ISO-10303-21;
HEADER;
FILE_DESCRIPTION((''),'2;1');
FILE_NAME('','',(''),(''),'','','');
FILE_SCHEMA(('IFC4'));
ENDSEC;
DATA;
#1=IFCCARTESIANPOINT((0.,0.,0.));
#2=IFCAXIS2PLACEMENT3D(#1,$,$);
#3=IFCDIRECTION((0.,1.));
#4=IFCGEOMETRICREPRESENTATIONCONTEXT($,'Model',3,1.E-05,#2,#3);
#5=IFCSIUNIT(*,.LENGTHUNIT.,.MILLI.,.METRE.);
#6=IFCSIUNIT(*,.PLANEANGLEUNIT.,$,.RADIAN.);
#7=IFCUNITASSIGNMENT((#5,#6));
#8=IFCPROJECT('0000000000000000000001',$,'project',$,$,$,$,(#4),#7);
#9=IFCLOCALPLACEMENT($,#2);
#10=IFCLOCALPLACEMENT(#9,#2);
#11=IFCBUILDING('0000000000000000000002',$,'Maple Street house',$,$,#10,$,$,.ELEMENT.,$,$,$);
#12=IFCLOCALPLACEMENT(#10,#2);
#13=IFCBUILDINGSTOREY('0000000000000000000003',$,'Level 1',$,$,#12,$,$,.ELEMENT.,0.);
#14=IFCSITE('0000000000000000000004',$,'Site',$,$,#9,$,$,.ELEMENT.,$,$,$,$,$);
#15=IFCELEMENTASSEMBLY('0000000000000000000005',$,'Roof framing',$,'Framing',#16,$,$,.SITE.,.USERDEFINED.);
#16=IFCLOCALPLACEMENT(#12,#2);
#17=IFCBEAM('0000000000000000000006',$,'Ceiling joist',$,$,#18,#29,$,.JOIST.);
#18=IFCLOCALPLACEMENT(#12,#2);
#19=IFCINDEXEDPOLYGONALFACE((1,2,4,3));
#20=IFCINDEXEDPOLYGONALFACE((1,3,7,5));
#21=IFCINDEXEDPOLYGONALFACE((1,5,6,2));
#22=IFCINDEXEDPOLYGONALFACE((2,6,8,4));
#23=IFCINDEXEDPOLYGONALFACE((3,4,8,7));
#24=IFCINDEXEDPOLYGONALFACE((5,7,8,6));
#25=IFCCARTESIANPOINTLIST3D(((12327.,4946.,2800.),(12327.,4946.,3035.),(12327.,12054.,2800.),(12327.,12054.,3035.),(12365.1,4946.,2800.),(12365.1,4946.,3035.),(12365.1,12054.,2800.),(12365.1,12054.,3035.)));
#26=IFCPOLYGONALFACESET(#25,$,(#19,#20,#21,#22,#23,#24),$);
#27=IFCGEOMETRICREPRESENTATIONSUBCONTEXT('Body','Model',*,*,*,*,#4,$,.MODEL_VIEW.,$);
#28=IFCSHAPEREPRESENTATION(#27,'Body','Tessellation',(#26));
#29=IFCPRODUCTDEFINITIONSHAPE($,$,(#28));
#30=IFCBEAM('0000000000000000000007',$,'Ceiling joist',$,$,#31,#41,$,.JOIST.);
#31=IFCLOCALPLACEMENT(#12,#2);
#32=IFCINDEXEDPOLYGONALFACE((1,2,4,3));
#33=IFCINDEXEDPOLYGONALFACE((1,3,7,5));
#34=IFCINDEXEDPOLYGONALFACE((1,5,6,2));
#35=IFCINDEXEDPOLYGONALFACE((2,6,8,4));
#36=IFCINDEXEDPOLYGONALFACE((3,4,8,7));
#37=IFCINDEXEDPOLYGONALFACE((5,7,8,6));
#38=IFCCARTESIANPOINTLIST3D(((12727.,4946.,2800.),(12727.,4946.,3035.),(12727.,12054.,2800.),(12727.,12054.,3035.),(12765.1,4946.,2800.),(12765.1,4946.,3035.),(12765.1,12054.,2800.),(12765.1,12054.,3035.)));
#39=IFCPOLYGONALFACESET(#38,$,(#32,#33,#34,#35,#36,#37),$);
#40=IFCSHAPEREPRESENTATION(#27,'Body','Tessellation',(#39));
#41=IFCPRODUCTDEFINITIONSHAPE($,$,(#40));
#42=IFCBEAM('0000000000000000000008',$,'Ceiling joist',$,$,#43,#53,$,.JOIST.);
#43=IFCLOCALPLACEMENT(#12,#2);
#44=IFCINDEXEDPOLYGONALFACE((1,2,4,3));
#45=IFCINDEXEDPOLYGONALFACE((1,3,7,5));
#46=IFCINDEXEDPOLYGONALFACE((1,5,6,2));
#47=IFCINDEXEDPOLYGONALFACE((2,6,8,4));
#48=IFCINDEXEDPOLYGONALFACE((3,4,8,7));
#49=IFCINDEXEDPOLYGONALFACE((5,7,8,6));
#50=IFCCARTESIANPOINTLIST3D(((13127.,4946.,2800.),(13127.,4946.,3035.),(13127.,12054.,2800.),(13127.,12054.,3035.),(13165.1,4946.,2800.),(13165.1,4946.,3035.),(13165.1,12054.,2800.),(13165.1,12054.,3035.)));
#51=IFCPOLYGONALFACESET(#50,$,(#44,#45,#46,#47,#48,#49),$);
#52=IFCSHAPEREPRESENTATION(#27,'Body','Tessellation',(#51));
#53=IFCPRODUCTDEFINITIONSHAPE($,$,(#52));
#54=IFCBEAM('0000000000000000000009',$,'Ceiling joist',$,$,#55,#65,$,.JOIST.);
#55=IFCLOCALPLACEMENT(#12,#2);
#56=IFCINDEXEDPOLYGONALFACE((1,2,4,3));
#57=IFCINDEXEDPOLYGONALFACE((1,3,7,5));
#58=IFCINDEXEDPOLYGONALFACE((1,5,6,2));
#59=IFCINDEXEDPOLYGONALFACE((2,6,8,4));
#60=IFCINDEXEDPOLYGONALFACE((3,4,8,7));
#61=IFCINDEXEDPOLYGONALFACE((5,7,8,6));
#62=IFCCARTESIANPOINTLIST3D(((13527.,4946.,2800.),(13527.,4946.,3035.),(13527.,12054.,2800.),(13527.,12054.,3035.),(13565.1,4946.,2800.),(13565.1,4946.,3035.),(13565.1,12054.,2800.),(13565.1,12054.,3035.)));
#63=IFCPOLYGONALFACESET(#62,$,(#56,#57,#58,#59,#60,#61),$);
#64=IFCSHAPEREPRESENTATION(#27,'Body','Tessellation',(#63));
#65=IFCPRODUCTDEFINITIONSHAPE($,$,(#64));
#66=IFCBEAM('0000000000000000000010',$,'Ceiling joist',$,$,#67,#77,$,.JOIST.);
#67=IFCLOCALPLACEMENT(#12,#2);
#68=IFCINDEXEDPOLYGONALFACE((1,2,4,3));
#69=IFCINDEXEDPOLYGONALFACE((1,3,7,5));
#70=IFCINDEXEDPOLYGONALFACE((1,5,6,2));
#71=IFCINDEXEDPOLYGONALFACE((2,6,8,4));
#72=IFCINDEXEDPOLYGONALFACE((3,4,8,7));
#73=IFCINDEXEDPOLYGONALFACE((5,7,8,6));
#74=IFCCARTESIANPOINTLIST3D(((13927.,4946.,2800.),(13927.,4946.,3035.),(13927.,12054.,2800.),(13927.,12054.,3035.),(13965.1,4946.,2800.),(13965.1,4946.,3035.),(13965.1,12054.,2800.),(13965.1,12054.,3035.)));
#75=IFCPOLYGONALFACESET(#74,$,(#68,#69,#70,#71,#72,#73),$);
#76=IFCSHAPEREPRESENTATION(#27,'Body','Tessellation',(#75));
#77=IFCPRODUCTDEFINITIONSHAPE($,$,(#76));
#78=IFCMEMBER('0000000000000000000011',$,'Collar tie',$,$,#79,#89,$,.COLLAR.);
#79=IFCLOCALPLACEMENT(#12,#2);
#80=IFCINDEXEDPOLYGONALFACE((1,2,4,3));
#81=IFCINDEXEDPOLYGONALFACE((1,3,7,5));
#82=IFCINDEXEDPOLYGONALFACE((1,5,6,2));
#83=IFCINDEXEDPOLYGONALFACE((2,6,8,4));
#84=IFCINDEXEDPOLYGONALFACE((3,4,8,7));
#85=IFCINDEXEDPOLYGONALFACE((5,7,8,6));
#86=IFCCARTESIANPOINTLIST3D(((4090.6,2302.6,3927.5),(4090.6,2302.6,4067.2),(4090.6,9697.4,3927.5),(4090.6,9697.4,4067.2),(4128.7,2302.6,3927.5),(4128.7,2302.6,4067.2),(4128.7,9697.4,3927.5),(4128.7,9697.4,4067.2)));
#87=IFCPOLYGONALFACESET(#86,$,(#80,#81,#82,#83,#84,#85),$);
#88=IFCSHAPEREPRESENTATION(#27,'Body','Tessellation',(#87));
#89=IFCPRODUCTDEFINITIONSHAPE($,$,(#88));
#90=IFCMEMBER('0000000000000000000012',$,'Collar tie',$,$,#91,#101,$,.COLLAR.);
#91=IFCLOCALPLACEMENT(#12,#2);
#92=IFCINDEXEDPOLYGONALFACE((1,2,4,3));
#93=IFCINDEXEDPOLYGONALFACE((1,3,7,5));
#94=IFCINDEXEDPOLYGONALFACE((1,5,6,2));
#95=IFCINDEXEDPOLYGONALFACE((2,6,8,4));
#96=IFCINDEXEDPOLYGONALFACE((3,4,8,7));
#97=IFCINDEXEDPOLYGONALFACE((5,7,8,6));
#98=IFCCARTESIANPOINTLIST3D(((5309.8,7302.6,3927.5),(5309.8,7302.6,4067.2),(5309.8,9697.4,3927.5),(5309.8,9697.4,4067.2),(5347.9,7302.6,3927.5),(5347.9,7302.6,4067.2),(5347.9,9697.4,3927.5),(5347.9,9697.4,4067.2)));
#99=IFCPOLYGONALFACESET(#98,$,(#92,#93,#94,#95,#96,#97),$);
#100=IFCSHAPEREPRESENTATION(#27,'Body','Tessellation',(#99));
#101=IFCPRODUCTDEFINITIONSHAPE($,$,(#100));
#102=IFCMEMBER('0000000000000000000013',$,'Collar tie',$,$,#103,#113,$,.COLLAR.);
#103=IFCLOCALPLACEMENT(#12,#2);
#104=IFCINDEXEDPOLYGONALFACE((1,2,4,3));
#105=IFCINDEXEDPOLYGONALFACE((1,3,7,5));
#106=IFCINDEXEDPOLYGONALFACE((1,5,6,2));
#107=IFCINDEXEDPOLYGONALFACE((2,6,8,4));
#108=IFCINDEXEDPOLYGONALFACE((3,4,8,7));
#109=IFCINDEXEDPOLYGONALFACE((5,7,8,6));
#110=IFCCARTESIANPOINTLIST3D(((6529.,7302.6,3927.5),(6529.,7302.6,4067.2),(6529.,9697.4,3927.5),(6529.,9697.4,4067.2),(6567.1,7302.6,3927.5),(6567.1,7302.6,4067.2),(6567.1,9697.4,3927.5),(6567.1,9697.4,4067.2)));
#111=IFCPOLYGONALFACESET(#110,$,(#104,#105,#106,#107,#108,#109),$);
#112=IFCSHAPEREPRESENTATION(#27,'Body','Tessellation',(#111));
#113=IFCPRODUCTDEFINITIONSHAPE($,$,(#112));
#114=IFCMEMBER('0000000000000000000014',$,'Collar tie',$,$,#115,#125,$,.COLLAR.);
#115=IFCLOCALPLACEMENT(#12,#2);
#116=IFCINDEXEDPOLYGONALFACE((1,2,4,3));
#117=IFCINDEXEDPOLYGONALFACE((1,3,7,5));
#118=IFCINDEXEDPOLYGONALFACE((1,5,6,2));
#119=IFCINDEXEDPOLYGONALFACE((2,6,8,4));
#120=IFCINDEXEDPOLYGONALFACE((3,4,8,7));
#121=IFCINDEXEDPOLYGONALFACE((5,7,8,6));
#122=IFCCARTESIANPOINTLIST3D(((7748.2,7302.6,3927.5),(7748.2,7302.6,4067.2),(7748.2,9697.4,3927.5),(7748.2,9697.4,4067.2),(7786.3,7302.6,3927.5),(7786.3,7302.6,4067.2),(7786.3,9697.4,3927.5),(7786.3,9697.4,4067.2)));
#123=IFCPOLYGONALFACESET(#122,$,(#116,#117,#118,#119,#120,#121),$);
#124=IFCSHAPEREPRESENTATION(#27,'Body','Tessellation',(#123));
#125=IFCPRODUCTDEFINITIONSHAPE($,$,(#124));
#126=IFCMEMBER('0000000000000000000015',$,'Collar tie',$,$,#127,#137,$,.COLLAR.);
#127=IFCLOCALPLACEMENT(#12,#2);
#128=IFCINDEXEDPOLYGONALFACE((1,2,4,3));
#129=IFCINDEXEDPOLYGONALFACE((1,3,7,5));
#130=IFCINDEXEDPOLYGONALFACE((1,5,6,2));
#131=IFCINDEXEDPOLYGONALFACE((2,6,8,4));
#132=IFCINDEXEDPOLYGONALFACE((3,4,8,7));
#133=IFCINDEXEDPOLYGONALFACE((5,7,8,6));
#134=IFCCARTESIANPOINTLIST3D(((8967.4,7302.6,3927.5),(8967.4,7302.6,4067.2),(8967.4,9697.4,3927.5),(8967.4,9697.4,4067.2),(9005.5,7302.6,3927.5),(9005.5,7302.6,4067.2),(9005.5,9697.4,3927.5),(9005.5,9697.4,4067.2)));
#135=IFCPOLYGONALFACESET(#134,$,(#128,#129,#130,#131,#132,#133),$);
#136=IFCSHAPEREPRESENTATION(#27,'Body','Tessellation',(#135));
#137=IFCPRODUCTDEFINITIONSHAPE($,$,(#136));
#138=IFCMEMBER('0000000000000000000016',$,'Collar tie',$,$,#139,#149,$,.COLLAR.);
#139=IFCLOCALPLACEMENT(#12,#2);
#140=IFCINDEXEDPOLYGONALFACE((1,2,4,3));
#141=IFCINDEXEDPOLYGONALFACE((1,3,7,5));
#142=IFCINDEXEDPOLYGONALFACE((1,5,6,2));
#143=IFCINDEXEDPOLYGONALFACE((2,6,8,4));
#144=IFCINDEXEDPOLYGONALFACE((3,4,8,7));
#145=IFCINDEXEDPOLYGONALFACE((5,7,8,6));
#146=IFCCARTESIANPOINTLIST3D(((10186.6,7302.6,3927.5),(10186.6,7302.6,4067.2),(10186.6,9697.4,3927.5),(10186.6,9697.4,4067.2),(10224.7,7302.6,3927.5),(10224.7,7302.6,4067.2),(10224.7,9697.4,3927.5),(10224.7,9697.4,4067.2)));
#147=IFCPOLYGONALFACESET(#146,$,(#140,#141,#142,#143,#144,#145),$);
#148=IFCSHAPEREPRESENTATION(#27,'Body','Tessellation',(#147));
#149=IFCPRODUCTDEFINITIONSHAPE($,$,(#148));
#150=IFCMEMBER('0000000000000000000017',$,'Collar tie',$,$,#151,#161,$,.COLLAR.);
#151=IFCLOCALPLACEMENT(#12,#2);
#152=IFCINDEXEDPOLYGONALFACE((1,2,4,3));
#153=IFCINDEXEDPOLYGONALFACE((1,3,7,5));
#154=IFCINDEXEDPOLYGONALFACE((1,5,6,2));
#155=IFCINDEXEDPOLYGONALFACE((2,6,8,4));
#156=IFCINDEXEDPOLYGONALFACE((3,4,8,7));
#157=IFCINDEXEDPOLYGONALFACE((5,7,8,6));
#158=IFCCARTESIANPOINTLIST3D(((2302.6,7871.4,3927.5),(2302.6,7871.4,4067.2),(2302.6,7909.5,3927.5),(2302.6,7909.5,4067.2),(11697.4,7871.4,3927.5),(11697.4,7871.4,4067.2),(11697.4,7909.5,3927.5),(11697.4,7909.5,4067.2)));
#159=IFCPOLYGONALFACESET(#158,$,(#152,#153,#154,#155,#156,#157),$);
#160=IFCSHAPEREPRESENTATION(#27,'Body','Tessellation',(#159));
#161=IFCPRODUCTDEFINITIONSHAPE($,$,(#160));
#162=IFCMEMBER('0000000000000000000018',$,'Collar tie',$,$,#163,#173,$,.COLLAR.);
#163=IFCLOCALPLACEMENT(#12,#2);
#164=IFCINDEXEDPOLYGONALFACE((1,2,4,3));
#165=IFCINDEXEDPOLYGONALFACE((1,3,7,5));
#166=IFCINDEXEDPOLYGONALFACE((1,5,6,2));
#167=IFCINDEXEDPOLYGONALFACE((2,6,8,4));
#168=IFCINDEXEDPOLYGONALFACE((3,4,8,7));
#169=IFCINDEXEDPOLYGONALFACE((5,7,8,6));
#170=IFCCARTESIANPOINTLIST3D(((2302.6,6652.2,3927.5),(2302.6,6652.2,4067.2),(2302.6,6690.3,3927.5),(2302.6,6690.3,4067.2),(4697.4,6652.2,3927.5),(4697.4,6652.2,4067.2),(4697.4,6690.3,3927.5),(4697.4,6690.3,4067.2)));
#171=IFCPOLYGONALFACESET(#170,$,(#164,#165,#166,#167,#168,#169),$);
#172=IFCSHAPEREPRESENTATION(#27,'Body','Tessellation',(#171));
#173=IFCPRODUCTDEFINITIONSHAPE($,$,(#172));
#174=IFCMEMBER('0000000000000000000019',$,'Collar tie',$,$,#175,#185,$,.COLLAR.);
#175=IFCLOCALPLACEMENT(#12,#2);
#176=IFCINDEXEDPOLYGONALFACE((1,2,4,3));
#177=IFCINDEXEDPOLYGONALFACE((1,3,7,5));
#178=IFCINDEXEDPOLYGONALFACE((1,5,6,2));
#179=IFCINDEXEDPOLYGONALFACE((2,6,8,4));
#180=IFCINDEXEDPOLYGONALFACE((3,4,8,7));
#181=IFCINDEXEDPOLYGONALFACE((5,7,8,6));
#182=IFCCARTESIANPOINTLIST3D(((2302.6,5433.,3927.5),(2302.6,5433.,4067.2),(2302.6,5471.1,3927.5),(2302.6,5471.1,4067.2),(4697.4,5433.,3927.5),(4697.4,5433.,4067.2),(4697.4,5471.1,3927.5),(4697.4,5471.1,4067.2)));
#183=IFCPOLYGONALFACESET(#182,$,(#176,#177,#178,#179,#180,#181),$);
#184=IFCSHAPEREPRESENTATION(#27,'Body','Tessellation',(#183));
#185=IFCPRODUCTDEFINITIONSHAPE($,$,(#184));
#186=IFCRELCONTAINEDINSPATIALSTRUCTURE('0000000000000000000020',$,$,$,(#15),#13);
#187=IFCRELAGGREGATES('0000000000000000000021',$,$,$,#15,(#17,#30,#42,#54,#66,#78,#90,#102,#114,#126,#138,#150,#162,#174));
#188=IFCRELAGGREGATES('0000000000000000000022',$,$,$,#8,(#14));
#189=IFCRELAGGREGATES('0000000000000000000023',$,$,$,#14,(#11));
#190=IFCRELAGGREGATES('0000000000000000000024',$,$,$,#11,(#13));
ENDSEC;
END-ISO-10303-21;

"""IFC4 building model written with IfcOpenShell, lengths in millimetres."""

from ifc_helpers import new_model, si_unit, direction, frame, origin, origin_with_axes, place, context, subcontext, project, spatial, polyline, outline, extrude, element, aggregate, save


model = new_model("IFC4")

# Units and contexts
model_context = context("Model", 3, precision=1e-05, world=origin(), true_north=direction((0.0, 1.0)))
body_context = subcontext(model_context, "Body", "Model", "MODEL_VIEW")
ifc_project = project(units=[si_unit("LENGTHUNIT", "METRE", prefix="MILLI"), si_unit("PLANEANGLEUNIT", "RADIAN")], contexts=[model_context])

# Site, building, storey
site_placement = place(None, origin())
site = spatial("IfcSite", under=ifc_project, at=site_placement, Name="Site", CompositionType="ELEMENT")
building_placement = place(site_placement, origin())
building = spatial("IfcBuilding", under=site, at=building_placement, Name="Maple Street house", CompositionType="ELEMENT")
storey_placement = place(building_placement, origin())
storey = spatial("IfcBuildingStorey", under=building, at=storey_placement, Name="Level 1", CompositionType="ELEMENT", Elevation=0.0)

# Element assembly, beams, members
assembly_placement = place(storey_placement, origin_with_axes())
assembly = element("IfcElementAssembly", 1, at=assembly_placement, inside=storey, Name="Roof framing", ObjectType="Framing", AssemblyPlace="SITE", PredefinedType="USERDEFINED")
beam_1_placement = place(storey_placement, origin_with_axes())
beam_1 = element("IfcBeam", 2, at=beam_1_placement, Name="Ceiling joist", PredefinedType="JOIST", context=body_context, shape_type="SweptSolid", body=[
    extrude(outline(polyline([(0.0, 0.0), (38.1, 0.0), (38.1, 234.9), (0.0, 234.9), (0.0, 0.0)])), frame((12327.0, 12054.0, 2800.0), z_axis=(0.0, -1.0, 0.0), x_axis=(1.0, 0.0, 0.0)), (0.0, 0.0, 1.0), 7107.9),
])
beam_2_placement = place(storey_placement, origin_with_axes())
beam_2 = element("IfcBeam", 3, at=beam_2_placement, Name="Ceiling joist", PredefinedType="JOIST", context=body_context, shape_type="SweptSolid", body=[
    extrude(outline(polyline([(0.0, 0.0), (38.1, 0.0), (38.1, 234.9), (0.0, 234.9), (0.0, 0.0)])), frame((12727.0, 12054.0, 2800.0), z_axis=(0.0, -1.0, 0.0), x_axis=(1.0, 0.0, 0.0)), (0.0, 0.0, 1.0), 7107.9),
])
beam_3_placement = place(storey_placement, origin_with_axes())
beam_3 = element("IfcBeam", 4, at=beam_3_placement, Name="Ceiling joist", PredefinedType="JOIST", context=body_context, shape_type="SweptSolid", body=[
    extrude(outline(polyline([(0.0, 0.0), (38.1, 0.0), (38.1, 234.9), (0.0, 234.9), (0.0, 0.0)])), frame((13127.0, 12054.0, 2800.0), z_axis=(0.0, -1.0, 0.0), x_axis=(1.0, 0.0, 0.0)), (0.0, 0.0, 1.0), 7107.9),
])
beam_4_placement = place(storey_placement, origin_with_axes())
beam_4 = element("IfcBeam", 5, at=beam_4_placement, Name="Ceiling joist", PredefinedType="JOIST", context=body_context, shape_type="SweptSolid", body=[
    extrude(outline(polyline([(0.0, 0.0), (38.1, 0.0), (38.1, 234.9), (0.0, 234.9), (0.0, 0.0)])), frame((13527.0, 12054.0, 2800.0), z_axis=(0.0, -1.0, 0.0), x_axis=(1.0, 0.0, 0.0)), (0.0, 0.0, 1.0), 7107.9),
])
beam_5_placement = place(storey_placement, origin_with_axes())
beam_5 = element("IfcBeam", 6, at=beam_5_placement, Name="Ceiling joist", PredefinedType="JOIST", context=body_context, shape_type="SweptSolid", body=[
    extrude(outline(polyline([(0.0, 0.0), (38.1, 0.0), (38.1, 234.9), (0.0, 234.9), (0.0, 0.0)])), frame((13927.0, 12054.0, 2800.0), z_axis=(0.0, -1.0, 0.0), x_axis=(1.0, 0.0, 0.0)), (0.0, 0.0, 1.0), 7107.9),
])
member_1_placement = place(storey_placement, origin_with_axes())
member_1 = element("IfcMember", 7, at=member_1_placement, Name="Collar tie", PredefinedType="COLLAR", context=body_context, shape_type="SweptSolid", body=[
    extrude(outline(polyline([(0.0, 0.0), (38.1, 0.0), (38.1, 139.7), (0.0, 139.7), (0.0, 0.0)])), frame((4128.7, 2302.6, 3927.5), z_axis=(0.0, 1.0, 0.0), x_axis=(-1.0, 0.0, 0.0)), (0.0, 0.0, 1.0), 7394.7),
])
member_2_placement = place(storey_placement, origin_with_axes())
member_2 = element("IfcMember", 8, at=member_2_placement, Name="Collar tie", PredefinedType="COLLAR", context=body_context, shape_type="SweptSolid", body=[
    extrude(outline(polyline([(0.0, 0.0), (38.1, 0.0), (38.1, 139.7), (0.0, 139.7), (0.0, 0.0)])), frame((5347.9, 7302.6, 3927.5), z_axis=(0.0, 1.0, 0.0), x_axis=(-1.0, 0.0, 0.0)), (0.0, 0.0, 1.0), 2394.7),
])
member_3_placement = place(storey_placement, origin_with_axes())
member_3 = element("IfcMember", 9, at=member_3_placement, Name="Collar tie", PredefinedType="COLLAR", context=body_context, shape_type="SweptSolid", body=[
    extrude(outline(polyline([(0.0, 0.0), (38.1, 0.0), (38.1, 139.7), (0.0, 139.7), (0.0, 0.0)])), frame((6567.1, 7302.6, 3927.5), z_axis=(0.0, 1.0, 0.0), x_axis=(-1.0, 0.0, 0.0)), (0.0, 0.0, 1.0), 2394.7),
])
member_4_placement = place(storey_placement, origin_with_axes())
member_4 = element("IfcMember", 10, at=member_4_placement, Name="Collar tie", PredefinedType="COLLAR", context=body_context, shape_type="SweptSolid", body=[
    extrude(outline(polyline([(0.0, 0.0), (38.1, 0.0), (38.1, 139.7), (0.0, 139.7), (0.0, 0.0)])), frame((7786.3, 7302.6, 3927.5), z_axis=(0.0, 1.0, 0.0), x_axis=(-1.0, 0.0, 0.0)), (0.0, 0.0, 1.0), 2394.7),
])
member_5_placement = place(storey_placement, origin_with_axes())
member_5 = element("IfcMember", 11, at=member_5_placement, Name="Collar tie", PredefinedType="COLLAR", context=body_context, shape_type="SweptSolid", body=[
    extrude(outline(polyline([(0.0, 0.0), (38.1, 0.0), (38.1, 139.7), (0.0, 139.7), (0.0, 0.0)])), frame((9005.5, 7302.6, 3927.5), z_axis=(0.0, 1.0, 0.0), x_axis=(-1.0, 0.0, 0.0)), (0.0, 0.0, 1.0), 2394.7),
])
member_6_placement = place(storey_placement, origin_with_axes())
member_6 = element("IfcMember", 12, at=member_6_placement, Name="Collar tie", PredefinedType="COLLAR", context=body_context, shape_type="SweptSolid", body=[
    extrude(outline(polyline([(0.0, 0.0), (38.1, 0.0), (38.1, 139.7), (0.0, 139.7), (0.0, 0.0)])), frame((10224.7, 7302.6, 3927.5), z_axis=(0.0, 1.0, 0.0), x_axis=(-1.0, 0.0, 0.0)), (0.0, 0.0, 1.0), 2394.7),
])
member_7_placement = place(storey_placement, origin_with_axes())
member_7 = element("IfcMember", 13, at=member_7_placement, Name="Collar tie", PredefinedType="COLLAR", context=body_context, shape_type="SweptSolid", body=[
    extrude(outline(polyline([(0.0, 0.0), (38.1, 0.0), (38.1, 139.7), (0.0, 139.7), (0.0, 0.0)])), frame((2302.6, 7871.4, 3927.5), z_axis=(1.0, 0.0, 0.0), x_axis=(0.0, 1.0, 0.0)), (0.0, 0.0, 1.0), 9394.7),
])
member_8_placement = place(storey_placement, origin_with_axes())
member_8 = element("IfcMember", 14, at=member_8_placement, Name="Collar tie", PredefinedType="COLLAR", context=body_context, shape_type="SweptSolid", body=[
    extrude(outline(polyline([(0.0, 0.0), (38.1, 0.0), (38.1, 139.7), (0.0, 139.7), (0.0, 0.0)])), frame((2302.6, 6652.2, 3927.5), z_axis=(1.0, 0.0, 0.0), x_axis=(0.0, 1.0, 0.0)), (0.0, 0.0, 1.0), 2394.7),
])
member_9_placement = place(storey_placement, origin_with_axes())
member_9 = element("IfcMember", 15, at=member_9_placement, Name="Collar tie", PredefinedType="COLLAR", context=body_context, shape_type="SweptSolid", body=[
    extrude(outline(polyline([(0.0, 0.0), (38.1, 0.0), (38.1, 139.7), (0.0, 139.7), (0.0, 0.0)])), frame((2302.6, 5433.0, 3927.5), z_axis=(1.0, 0.0, 0.0), x_axis=(0.0, 1.0, 0.0)), (0.0, 0.0, 1.0), 2394.7),
])
aggregate(assembly, [beam_1, beam_2, beam_3, beam_4, beam_5, member_1, member_2, member_3, member_4, member_5, member_6, member_7, member_8, member_9])

save(model, "model.ifc")
